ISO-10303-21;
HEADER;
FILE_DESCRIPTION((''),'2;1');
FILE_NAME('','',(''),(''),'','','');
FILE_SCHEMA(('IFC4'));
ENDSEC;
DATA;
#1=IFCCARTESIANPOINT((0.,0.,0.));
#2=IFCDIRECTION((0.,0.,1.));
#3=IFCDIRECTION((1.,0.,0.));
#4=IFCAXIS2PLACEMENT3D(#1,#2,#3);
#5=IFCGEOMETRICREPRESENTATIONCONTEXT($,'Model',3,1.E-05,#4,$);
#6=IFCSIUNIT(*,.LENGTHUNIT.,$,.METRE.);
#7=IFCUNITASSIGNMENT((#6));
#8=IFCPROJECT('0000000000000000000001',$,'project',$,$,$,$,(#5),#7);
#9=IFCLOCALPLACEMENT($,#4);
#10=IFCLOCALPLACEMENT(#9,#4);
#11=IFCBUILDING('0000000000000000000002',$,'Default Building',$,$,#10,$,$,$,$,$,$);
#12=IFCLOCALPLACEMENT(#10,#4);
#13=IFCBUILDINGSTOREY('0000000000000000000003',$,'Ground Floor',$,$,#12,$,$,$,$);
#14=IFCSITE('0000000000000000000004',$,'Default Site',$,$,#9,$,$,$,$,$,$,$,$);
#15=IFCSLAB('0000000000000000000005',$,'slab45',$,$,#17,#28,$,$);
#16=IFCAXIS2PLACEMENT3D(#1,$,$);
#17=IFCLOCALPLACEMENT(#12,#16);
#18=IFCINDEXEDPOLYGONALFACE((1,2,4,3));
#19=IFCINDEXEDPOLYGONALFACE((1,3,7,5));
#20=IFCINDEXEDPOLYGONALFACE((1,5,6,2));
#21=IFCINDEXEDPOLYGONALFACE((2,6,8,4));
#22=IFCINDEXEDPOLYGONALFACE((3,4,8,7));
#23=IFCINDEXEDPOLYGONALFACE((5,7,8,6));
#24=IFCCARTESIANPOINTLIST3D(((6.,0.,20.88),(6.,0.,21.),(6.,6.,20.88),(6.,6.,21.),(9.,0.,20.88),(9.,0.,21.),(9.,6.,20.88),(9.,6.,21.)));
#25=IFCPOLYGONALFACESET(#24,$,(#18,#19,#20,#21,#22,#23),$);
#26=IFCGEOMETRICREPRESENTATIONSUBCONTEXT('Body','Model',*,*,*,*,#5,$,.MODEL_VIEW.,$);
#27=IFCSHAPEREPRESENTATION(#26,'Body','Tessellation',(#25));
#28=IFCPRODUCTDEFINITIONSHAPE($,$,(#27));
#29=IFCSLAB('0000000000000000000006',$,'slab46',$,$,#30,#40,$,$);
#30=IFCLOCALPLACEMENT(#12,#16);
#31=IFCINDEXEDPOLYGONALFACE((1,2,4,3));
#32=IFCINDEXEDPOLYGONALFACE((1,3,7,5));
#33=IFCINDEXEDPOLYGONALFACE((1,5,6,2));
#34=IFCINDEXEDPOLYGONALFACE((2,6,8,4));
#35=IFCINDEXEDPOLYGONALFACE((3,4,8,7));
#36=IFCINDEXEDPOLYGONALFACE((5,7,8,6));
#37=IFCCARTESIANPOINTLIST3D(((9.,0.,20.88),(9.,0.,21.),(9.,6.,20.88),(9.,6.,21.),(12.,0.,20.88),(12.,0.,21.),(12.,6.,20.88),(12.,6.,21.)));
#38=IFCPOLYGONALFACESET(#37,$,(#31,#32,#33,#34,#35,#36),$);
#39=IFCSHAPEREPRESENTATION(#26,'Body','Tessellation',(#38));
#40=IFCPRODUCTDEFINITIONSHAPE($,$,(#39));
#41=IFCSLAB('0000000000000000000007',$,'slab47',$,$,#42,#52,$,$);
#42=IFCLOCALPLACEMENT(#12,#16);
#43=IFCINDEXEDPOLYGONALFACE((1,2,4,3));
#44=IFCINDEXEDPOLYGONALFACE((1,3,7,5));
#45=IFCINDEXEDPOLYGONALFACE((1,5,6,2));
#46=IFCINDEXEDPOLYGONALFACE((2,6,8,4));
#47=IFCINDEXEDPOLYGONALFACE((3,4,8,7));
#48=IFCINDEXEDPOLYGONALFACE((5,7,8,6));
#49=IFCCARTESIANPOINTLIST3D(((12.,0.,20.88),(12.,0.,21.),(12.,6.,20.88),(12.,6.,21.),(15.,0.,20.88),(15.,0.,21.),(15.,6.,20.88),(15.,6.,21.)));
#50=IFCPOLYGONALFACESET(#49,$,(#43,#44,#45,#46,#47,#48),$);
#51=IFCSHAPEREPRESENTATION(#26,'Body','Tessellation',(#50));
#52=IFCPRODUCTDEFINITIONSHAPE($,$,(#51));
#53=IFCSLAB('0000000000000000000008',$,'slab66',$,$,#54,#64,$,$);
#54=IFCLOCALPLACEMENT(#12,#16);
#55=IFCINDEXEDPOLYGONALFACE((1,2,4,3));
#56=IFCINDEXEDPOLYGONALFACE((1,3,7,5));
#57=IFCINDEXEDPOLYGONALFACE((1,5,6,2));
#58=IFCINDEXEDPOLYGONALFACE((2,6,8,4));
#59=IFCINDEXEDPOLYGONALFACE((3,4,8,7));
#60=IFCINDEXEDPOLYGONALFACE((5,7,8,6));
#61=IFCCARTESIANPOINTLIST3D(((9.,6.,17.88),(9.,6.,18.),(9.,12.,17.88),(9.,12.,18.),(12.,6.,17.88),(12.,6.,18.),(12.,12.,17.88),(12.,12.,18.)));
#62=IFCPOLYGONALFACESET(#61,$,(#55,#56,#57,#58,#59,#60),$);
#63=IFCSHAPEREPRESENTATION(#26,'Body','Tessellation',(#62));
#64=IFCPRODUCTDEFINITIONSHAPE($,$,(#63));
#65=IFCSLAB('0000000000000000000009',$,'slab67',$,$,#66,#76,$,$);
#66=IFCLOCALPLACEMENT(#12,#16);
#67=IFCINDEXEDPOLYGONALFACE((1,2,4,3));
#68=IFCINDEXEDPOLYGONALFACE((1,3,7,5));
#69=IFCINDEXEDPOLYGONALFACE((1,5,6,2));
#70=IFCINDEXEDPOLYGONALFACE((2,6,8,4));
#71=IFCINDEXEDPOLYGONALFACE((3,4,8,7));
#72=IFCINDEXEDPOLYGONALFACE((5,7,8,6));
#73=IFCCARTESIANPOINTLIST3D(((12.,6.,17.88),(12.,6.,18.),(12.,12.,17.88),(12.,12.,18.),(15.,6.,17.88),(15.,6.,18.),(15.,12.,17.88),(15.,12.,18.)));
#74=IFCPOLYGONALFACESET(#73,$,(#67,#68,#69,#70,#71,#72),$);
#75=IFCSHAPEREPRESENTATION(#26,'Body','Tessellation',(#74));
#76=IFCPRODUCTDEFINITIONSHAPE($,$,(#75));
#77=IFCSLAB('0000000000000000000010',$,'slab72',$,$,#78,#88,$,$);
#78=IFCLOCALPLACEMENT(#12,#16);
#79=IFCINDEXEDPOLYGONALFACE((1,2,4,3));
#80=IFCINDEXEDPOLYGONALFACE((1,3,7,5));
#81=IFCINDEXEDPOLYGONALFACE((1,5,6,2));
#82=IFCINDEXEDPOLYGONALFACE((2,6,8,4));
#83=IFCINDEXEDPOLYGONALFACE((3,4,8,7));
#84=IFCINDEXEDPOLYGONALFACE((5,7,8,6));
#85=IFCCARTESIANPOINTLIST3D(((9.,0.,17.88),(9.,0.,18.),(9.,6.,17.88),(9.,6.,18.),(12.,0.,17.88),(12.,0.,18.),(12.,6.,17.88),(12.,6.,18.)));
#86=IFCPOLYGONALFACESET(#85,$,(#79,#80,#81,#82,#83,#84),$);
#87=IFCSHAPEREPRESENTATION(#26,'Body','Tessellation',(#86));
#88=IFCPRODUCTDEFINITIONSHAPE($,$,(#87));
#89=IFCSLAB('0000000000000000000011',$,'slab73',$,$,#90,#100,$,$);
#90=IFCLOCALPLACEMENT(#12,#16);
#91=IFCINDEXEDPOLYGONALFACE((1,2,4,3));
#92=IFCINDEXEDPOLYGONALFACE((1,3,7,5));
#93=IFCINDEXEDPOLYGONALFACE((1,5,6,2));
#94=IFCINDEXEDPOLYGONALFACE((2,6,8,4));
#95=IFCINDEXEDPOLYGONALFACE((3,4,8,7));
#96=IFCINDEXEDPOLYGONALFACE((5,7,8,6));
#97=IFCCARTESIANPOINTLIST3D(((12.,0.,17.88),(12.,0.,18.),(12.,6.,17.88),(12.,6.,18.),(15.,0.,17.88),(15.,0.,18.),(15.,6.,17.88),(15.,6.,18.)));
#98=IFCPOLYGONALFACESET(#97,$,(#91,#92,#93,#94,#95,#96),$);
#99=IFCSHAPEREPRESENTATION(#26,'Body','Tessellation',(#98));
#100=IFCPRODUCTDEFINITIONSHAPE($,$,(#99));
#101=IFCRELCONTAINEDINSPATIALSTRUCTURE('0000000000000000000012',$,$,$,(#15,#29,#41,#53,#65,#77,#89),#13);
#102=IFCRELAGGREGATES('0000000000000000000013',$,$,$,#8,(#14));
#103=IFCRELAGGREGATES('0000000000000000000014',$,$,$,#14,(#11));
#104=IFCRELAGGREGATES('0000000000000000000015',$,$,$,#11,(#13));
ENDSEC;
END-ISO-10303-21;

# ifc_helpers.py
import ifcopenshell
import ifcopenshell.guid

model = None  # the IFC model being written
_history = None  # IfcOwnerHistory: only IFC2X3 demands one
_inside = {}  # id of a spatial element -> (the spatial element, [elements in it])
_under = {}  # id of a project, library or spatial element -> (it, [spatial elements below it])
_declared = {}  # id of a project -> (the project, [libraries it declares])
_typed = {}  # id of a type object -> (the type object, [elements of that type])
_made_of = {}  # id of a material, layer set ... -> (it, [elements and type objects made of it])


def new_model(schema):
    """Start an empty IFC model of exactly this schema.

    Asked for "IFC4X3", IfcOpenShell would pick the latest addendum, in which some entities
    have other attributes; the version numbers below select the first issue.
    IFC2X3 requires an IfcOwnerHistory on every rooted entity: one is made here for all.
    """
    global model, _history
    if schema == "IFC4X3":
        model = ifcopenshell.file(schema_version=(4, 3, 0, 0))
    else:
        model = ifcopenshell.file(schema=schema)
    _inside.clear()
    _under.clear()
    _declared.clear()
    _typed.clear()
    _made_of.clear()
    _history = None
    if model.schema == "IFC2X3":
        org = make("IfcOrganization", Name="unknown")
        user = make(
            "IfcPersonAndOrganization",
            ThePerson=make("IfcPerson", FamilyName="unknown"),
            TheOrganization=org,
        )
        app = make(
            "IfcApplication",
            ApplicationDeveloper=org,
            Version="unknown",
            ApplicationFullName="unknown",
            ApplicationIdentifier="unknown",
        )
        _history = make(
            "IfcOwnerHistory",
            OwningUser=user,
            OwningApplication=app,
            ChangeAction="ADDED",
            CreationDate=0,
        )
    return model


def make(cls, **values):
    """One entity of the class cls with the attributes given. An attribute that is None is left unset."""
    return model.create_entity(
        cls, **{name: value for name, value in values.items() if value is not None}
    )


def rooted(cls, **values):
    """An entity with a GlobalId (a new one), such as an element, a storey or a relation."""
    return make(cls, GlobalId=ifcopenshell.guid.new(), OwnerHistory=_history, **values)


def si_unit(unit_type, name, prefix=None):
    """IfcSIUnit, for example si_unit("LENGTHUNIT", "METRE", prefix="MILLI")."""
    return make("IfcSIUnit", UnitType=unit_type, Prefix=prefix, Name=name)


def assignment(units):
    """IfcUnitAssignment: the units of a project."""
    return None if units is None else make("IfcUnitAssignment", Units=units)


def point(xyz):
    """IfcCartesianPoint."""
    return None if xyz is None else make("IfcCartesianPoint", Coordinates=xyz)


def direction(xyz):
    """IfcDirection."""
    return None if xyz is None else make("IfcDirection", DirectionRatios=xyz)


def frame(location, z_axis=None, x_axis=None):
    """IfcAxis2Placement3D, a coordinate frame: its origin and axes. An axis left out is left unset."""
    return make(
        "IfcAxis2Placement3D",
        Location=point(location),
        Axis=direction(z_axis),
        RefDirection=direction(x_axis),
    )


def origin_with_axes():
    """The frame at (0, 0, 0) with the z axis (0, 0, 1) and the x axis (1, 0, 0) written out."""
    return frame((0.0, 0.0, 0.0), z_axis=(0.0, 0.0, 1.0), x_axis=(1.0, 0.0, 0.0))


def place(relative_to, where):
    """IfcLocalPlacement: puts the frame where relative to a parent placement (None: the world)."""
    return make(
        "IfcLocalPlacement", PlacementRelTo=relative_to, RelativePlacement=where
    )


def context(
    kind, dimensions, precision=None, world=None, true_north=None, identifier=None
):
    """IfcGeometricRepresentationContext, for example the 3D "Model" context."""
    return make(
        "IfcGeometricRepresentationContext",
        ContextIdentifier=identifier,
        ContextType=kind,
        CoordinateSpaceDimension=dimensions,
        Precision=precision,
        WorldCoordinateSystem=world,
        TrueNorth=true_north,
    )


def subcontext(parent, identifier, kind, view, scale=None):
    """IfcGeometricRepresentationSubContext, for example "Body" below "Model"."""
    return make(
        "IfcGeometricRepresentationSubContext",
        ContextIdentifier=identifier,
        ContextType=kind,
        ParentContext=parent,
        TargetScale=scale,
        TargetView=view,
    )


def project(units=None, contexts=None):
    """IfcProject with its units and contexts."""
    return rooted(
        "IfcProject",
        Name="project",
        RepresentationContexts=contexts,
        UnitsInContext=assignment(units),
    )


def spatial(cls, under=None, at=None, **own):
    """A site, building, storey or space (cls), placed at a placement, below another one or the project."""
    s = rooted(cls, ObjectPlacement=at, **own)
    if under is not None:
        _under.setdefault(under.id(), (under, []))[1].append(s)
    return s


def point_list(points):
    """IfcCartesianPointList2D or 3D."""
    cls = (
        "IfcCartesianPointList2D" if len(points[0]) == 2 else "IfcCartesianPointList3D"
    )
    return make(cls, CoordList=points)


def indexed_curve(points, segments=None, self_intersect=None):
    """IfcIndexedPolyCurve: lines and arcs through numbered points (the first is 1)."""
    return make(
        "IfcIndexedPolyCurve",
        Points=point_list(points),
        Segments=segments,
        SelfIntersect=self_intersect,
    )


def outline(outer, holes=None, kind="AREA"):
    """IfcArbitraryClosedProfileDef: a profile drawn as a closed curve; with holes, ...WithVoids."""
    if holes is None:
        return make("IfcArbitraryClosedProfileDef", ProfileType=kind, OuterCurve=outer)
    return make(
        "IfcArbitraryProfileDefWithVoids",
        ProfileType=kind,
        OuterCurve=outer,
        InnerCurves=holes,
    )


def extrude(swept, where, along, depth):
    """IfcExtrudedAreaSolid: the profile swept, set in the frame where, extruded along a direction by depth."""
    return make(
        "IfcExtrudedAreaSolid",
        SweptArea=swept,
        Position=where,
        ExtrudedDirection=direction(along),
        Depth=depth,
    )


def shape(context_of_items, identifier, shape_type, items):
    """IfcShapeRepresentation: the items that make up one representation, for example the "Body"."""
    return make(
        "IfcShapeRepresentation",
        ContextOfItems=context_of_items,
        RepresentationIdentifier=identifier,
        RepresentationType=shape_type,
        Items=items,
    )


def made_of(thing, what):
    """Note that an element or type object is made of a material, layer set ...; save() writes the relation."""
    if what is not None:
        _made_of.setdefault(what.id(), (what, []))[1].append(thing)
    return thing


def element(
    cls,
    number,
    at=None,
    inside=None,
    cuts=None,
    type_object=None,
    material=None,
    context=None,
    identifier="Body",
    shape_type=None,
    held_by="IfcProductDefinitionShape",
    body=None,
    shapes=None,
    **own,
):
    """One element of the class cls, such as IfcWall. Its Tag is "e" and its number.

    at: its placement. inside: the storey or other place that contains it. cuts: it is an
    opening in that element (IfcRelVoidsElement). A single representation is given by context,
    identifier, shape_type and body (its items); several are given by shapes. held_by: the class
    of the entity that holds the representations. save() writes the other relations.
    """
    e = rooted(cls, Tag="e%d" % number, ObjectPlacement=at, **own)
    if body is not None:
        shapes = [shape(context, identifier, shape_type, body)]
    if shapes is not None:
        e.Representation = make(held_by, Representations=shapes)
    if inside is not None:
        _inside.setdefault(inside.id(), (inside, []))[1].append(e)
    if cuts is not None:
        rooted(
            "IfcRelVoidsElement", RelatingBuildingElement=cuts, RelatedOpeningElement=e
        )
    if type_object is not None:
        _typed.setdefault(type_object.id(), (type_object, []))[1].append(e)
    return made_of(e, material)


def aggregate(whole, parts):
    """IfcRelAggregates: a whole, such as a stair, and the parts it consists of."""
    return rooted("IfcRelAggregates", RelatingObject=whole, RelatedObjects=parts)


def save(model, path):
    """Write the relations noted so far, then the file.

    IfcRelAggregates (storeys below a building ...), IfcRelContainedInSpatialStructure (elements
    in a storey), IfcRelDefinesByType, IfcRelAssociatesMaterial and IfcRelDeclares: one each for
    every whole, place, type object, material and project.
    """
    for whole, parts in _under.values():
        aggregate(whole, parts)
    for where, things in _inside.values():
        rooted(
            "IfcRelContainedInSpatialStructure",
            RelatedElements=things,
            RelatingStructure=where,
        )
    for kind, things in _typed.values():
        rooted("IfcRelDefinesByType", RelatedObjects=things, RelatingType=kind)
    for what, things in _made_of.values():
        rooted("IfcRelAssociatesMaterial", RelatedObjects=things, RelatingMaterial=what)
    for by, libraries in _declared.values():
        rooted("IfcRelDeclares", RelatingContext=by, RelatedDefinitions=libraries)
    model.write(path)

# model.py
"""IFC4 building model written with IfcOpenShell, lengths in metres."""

from ifc_helpers import new_model, si_unit, frame, origin_with_axes, place, context, subcontext, project, spatial, indexed_curve, outline, extrude, element, save


model = new_model("IFC4")

# Units and contexts
model_context = context("Model", 3, precision=1e-05, world=origin_with_axes())
body_context = subcontext(model_context, "Body", "Model", "MODEL_VIEW")
ifc_project = project(units=[si_unit("LENGTHUNIT", "METRE")], contexts=[model_context])

# Site, building, storey
site_placement = place(None, origin_with_axes())
site = spatial("IfcSite", under=ifc_project, at=site_placement, Name="Default Site")
building_placement = place(site_placement, origin_with_axes())
building = spatial("IfcBuilding", under=site, at=building_placement, Name="Default Building")
storey_placement = place(building_placement, origin_with_axes())
storey = spatial("IfcBuildingStorey", under=building, at=storey_placement, Name="Ground Floor")

# Slabs
for number, where, z_axis, x_axis, name in (
    (1, (6.0, 0.0, 20.88), (0.0, 0.0, 1.0), (1.0, 0.0, 0.0), "slab45"),
    (2, (9.0, 0.0, 20.88), (0.0, 0.0, 1.0), (1.0, 0.0, 0.0), "slab46"),
    (3, (12.0, 0.0, 20.88), (0.0, 0.0, 1.0), (1.0, 0.0, 0.0), "slab47"),
    (4, (9.0, 6.0, 17.88), (0.0, 0.0, 1.0), (1.0, 0.0, 0.0), "slab66"),
    (5, (12.0, 6.0, 17.88), (0.0, 0.0, 1.0), (1.0, 0.0, 0.0), "slab67"),
    (6, (9.0, 0.0, 17.88), (0.0, 0.0, 1.0), (1.0, 0.0, 0.0), "slab72"),
    (7, (12.0, 0.0, 17.88), (0.0, 0.0, 1.0), (1.0, 0.0, 0.0), "slab73"),
):
    element("IfcSlab", number, at=place(storey_placement, frame(where, z_axis=z_axis, x_axis=x_axis)), inside=storey, Name=name, context=body_context, shape_type="SweptSolid", body=[
        extrude(outline(indexed_curve([(0.0, 0.0), (0.0, 6.0), (3.0, 6.0), (3.0, 0.0), (0.0, 0.0)], self_intersect=False)), origin_with_axes(), (0.0, 0.0, 1.0), 0.12),
    ])

save(model, "model.ifc")
